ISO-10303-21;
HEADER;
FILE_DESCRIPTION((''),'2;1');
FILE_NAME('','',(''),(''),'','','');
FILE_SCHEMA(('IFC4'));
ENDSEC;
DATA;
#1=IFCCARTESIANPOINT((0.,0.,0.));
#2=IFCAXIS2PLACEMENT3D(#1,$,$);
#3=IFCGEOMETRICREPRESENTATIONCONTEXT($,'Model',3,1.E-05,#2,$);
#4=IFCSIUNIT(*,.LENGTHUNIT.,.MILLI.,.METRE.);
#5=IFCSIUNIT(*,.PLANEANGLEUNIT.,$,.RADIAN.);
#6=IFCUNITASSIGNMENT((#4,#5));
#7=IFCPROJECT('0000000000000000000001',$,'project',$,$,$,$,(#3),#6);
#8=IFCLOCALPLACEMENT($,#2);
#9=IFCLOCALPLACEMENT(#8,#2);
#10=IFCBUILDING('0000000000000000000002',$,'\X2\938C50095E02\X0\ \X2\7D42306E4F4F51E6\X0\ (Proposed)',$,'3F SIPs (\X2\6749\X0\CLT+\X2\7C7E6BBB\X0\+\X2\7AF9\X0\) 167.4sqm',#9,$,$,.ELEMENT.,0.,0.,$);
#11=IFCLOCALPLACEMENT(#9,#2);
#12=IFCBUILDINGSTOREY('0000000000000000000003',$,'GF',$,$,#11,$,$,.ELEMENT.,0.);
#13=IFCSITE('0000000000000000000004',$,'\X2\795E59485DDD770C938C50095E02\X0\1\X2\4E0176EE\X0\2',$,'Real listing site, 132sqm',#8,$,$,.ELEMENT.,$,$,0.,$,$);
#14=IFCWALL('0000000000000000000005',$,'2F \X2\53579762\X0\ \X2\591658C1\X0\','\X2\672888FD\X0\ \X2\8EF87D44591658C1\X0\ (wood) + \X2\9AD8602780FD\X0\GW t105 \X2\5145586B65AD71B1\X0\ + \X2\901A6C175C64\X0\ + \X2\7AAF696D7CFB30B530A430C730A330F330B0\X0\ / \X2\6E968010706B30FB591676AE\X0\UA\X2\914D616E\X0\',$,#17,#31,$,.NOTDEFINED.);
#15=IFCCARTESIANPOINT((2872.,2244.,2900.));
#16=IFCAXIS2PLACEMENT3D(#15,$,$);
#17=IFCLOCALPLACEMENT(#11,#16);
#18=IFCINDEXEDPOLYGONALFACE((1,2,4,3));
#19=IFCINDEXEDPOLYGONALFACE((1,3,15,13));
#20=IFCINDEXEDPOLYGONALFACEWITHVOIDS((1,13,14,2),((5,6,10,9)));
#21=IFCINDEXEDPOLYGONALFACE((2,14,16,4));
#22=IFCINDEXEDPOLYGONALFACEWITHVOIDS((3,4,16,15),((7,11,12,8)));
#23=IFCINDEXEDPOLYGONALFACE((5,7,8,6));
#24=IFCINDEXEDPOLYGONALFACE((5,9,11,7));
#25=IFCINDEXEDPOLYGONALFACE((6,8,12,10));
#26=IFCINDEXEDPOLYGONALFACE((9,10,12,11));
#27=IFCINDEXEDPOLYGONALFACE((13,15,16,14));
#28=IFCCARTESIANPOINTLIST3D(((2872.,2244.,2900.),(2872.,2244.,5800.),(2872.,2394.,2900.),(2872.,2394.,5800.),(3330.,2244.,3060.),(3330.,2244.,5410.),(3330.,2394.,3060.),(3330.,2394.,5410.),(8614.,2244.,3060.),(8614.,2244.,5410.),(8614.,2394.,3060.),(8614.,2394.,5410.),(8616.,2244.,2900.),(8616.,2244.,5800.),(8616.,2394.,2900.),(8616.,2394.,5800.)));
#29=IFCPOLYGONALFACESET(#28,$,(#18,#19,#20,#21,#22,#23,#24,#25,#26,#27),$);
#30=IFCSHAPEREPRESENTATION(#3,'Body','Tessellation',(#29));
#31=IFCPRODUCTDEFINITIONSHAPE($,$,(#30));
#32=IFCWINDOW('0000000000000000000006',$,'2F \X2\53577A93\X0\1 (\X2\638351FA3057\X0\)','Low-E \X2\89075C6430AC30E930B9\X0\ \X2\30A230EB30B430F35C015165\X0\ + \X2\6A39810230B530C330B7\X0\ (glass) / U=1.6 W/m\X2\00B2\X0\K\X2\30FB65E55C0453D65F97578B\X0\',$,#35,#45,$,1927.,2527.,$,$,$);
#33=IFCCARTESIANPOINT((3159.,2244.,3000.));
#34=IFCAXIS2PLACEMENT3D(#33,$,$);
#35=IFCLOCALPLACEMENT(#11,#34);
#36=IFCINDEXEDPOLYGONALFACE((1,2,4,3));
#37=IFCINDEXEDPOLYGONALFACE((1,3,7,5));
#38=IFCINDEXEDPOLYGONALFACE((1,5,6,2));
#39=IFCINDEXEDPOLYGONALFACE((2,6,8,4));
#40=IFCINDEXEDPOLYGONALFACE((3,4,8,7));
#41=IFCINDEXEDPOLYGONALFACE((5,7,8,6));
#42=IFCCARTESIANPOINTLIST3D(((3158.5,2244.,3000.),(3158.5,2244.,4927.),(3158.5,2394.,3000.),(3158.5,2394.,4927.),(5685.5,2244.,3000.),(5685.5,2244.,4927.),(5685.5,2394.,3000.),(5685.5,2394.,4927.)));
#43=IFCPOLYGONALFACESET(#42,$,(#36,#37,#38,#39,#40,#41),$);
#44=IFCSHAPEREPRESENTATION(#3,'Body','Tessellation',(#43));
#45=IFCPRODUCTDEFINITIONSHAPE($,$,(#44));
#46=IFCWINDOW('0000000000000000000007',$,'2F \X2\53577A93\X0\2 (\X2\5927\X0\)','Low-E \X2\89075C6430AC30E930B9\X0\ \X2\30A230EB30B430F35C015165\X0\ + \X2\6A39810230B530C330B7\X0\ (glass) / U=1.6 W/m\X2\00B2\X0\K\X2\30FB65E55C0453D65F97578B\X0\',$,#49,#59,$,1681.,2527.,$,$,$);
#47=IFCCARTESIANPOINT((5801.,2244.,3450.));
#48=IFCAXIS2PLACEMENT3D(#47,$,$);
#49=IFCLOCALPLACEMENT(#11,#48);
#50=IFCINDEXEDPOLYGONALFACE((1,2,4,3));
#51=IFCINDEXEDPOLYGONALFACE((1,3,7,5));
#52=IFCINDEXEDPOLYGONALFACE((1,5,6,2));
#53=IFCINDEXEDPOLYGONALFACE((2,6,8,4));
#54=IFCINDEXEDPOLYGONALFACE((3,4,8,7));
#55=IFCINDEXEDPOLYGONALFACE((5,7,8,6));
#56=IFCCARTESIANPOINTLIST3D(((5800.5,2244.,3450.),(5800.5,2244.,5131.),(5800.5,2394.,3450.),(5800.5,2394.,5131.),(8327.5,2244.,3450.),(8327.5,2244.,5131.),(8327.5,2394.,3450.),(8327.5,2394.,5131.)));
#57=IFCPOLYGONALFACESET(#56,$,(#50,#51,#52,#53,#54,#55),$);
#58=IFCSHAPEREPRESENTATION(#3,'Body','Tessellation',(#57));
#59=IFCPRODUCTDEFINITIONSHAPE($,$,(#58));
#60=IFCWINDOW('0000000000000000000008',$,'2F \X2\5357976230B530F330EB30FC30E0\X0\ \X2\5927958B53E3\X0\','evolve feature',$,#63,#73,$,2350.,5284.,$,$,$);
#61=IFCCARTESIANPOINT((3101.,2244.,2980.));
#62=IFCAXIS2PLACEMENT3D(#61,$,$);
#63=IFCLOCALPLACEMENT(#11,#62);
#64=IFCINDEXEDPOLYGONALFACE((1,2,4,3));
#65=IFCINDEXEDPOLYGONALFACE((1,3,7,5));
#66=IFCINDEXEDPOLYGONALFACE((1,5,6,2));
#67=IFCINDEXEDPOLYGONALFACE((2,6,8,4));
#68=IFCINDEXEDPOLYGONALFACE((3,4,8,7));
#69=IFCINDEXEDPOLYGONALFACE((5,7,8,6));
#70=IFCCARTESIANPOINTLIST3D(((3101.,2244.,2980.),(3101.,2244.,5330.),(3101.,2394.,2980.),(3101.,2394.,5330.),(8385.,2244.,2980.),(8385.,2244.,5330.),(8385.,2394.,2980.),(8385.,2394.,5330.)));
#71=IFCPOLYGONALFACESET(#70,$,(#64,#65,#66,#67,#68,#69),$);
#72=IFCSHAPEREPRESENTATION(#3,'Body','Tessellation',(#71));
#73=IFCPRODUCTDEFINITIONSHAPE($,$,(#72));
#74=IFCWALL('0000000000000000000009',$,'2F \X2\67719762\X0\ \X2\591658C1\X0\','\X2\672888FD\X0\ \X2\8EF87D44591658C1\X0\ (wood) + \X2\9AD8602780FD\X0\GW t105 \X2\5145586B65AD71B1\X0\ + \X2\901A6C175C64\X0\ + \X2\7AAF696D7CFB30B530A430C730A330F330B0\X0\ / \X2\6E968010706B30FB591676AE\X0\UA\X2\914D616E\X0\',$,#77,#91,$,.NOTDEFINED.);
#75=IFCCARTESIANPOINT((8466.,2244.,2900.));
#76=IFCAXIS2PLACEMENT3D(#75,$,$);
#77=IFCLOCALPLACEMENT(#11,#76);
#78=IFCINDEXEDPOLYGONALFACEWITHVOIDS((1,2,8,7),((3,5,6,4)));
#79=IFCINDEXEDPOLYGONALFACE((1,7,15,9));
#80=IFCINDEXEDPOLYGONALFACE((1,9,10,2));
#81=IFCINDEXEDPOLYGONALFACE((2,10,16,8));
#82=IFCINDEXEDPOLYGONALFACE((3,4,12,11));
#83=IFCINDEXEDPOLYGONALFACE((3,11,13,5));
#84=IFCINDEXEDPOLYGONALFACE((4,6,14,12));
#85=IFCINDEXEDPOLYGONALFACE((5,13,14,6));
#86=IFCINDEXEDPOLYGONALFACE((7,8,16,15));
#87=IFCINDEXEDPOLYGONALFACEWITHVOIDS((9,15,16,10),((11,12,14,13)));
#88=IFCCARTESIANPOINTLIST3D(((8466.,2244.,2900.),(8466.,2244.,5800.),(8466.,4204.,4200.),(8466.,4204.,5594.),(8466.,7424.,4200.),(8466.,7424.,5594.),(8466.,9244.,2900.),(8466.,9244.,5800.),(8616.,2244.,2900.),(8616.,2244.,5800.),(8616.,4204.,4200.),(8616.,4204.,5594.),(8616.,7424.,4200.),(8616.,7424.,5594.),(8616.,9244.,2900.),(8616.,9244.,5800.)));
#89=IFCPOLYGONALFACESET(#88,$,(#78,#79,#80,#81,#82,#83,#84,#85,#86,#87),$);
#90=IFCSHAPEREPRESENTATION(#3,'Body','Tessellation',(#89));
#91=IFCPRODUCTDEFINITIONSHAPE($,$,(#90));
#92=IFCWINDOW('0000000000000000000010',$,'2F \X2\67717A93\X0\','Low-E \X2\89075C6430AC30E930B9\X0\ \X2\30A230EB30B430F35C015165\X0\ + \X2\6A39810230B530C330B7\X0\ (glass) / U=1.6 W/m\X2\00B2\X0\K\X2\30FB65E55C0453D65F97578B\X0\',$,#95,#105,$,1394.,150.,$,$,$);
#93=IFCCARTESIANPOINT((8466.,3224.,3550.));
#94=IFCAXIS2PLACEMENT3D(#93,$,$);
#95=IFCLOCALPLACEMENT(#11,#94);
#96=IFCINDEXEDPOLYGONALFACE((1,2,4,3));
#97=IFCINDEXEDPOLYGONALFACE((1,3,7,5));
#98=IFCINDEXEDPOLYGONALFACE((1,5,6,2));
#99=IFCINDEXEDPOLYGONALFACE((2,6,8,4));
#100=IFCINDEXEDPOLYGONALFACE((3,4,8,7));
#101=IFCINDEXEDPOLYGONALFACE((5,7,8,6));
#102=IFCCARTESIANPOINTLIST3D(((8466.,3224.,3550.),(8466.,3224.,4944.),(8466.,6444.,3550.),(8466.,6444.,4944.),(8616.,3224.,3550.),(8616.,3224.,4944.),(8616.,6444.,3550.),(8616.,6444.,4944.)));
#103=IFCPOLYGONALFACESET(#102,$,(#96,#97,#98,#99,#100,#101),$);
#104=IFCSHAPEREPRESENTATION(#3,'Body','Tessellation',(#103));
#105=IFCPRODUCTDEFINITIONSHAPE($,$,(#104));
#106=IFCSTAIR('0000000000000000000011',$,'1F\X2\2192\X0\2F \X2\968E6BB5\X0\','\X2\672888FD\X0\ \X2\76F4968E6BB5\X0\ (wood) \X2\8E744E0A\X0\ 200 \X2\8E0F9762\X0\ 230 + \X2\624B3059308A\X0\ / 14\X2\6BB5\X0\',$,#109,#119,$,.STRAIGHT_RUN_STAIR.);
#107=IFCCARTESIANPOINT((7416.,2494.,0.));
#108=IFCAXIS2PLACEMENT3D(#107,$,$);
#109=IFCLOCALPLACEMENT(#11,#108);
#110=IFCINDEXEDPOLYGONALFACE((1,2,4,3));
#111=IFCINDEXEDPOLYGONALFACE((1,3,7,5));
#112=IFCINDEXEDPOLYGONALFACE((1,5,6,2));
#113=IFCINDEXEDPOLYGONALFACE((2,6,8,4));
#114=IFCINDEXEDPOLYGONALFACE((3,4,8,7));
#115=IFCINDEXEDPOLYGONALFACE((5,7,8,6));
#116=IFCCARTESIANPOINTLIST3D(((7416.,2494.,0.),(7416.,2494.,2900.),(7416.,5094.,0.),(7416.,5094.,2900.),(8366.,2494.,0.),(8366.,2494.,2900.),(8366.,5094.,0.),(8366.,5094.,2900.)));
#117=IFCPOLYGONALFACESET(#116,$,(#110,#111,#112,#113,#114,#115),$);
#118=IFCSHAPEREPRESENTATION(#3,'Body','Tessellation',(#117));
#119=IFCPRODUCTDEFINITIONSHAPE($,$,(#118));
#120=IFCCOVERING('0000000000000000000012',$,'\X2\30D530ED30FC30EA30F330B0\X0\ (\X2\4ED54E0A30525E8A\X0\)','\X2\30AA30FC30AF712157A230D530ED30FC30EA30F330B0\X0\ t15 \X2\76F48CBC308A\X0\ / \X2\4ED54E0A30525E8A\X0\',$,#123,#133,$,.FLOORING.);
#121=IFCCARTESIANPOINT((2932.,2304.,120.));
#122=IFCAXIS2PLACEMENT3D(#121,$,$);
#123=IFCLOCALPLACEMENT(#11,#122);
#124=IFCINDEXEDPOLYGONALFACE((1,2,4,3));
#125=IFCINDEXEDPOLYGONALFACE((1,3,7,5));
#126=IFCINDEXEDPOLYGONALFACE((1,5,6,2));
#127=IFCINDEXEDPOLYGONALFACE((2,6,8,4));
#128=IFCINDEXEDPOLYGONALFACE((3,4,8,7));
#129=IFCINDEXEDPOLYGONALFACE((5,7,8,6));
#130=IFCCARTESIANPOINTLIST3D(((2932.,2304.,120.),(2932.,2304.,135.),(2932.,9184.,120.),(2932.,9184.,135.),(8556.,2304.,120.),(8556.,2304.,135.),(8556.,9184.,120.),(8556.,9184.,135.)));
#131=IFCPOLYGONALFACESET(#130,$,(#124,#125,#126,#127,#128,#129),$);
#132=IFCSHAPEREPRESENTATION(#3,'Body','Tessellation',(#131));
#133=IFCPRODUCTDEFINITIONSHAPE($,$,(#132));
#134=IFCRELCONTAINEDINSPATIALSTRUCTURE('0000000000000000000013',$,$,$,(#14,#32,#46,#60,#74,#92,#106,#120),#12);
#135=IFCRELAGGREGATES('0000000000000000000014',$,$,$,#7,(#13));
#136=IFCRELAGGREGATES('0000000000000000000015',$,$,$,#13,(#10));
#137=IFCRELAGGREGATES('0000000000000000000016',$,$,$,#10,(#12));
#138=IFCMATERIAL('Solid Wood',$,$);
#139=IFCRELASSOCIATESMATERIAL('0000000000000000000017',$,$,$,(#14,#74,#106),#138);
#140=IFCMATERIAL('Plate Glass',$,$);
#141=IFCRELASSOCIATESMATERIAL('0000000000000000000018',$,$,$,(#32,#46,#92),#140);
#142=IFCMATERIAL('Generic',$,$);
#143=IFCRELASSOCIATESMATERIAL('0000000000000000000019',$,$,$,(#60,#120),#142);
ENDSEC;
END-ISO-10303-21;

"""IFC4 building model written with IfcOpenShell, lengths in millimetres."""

from ifc_helpers import new_model, si_unit, frame, frame_2d, origin, place, context, project, spatial, rectangle, extrude, material, element, fill, save


model = new_model("IFC4")

# Units and contexts
model_context = context("Model", 3, precision=1e-05, world=origin())
ifc_project = project(units=[si_unit("LENGTHUNIT", "METRE", prefix="MILLI"), si_unit("PLANEANGLEUNIT", "RADIAN")], contexts=[model_context])

# Site, building, storey
site_placement = place(None, origin())
site = spatial("IfcSite", under=ifc_project, at=site_placement, Name="神奈川県鎌倉市1丁目2", ObjectType="Real listing site, 132sqm", CompositionType="ELEMENT", RefElevation=0.0)
building_placement = place(site_placement, origin())
building = spatial("IfcBuilding", under=site, at=building_placement, Name="鎌倉市 終の住処 (Proposed)", ObjectType="3F SIPs (杉CLT+籾殻+竹) 167.4sqm", CompositionType="ELEMENT", ElevationOfRefHeight=0.0, ElevationOfTerrain=0.0)
storey_placement = place(building_placement, origin())
storey = spatial("IfcBuildingStorey", under=building, at=storey_placement, Name="GF", CompositionType="ELEMENT", Elevation=0.0)

# Shared definitions
ifc_material_1 = material(Name="Solid Wood")

# Shared definitions
ifc_material_2 = material(Name="Plate Glass")
ifc_material_3 = material(Name="Generic")

# Wall, openings, windows
wall_1_placement = place(storey_placement, frame((2872.0, 2244.0, 2900.0)))
wall_1 = element("IfcWall", 1, at=wall_1_placement, inside=storey, material=ifc_material_1, Name="2F 南面 外壁", Description="木製 軸組外壁 (wood) + 高性能GW t105 充填断熱 + 通気層 + 窯業系サイディング / 準耐火・外皮UA配慮", PredefinedType="NOTDEFINED", context=model_context, shape_type="SweptSolid", body=[
    extrude(rectangle(XDim=5744.0, YDim=150.0, at=frame_2d((2872.0, 75.0))), frame((2872.0, 2244.0, 2900.0)), (0.0, 0.0, 1.0), 2900.0),
])
opening_1_placement = place(storey_placement, frame((3159.0, 2244.0, 3000.0)))
opening_1 = element("IfcOpeningElement", 2, at=opening_1_placement, cuts=wall_1, PredefinedType="NOTDEFINED", context=model_context, shape_type="SweptSolid", body=[
    extrude(rectangle(XDim=2527.0, YDim=150.0, at=frame_2d((1263.0, 75.0))), frame((3159.0, 2244.0, 3000.0)), (0.0, 0.0, 1.0), 1927.0),
])
opening_2_placement = place(storey_placement, frame((5801.0, 2244.0, 3450.0)))
opening_2 = element("IfcOpeningElement", 3, at=opening_2_placement, cuts=wall_1, PredefinedType="NOTDEFINED", context=model_context, shape_type="SweptSolid", body=[
    extrude(rectangle(XDim=2527.0, YDim=150.0, at=frame_2d((1263.0, 75.0))), frame((5801.0, 2244.0, 3450.0)), (0.0, 0.0, 1.0), 1681.0),
])
opening_3_placement = place(storey_placement, frame((3101.0, 2244.0, 2980.0)))
opening_3 = element("IfcOpeningElement", 4, at=opening_3_placement, cuts=wall_1, PredefinedType="NOTDEFINED", context=model_context, shape_type="SweptSolid", body=[
    extrude(rectangle(XDim=5284.0, YDim=150.0, at=frame_2d((2642.0, 75.0))), frame((3101.0, 2244.0, 2980.0)), (0.0, 0.0, 1.0), 2350.0),
])
window_1_placement = place(storey_placement, frame((3159.0, 2244.0, 3000.0)))
window_1 = element("IfcWindow", 5, at=window_1_placement, inside=storey, material=ifc_material_2, Name="2F 南窓1 (掃出し)", Description="Low-E 複層ガラス アルゴン封入 + 樹脂サッシ (glass) / U=1.6 W/m²K・日射取得型", OverallHeight=1927.0, OverallWidth=2527.0, context=model_context, shape_type="SweptSolid", body=[
    extrude(rectangle(XDim=2527.0, YDim=150.0, at=frame_2d((1263.0, 75.0))), frame((3159.0, 2244.0, 3000.0)), (0.0, 0.0, 1.0), 1927.0),
])
fill(opening_1, window_1)
window_2_placement = place(storey_placement, frame((5801.0, 2244.0, 3450.0)))
window_2 = element("IfcWindow", 6, at=window_2_placement, inside=storey, material=ifc_material_2, Name="2F 南窓2 (大)", Description="Low-E 複層ガラス アルゴン封入 + 樹脂サッシ (glass) / U=1.6 W/m²K・日射取得型", OverallHeight=1681.0, OverallWidth=2527.0, context=model_context, shape_type="SweptSolid", body=[
    extrude(rectangle(XDim=2527.0, YDim=150.0, at=frame_2d((1263.0, 75.0))), frame((5801.0, 2244.0, 3450.0)), (0.0, 0.0, 1.0), 1681.0),
])
fill(opening_2, window_2)
window_3_placement = place(storey_placement, frame((3101.0, 2244.0, 2980.0)))
window_3 = element("IfcWindow", 7, at=window_3_placement, inside=storey, material=ifc_material_3, Name="2F 南面サンルーム 大開口", Description="evolve feature", OverallHeight=2350.0, OverallWidth=5284.0, context=model_context, shape_type="SweptSolid", body=[
    extrude(rectangle(XDim=5284.0, YDim=150.0, at=frame_2d((2642.0, 75.0))), frame((3101.0, 2244.0, 2980.0)), (0.0, 0.0, 1.0), 2350.0),
])
fill(opening_3, window_3)

# Wall, opening, window
wall_2_placement = place(storey_placement, frame((8466.0, 2244.0, 2900.0)))
wall_2 = element("IfcWall", 8, at=wall_2_placement, inside=storey, material=ifc_material_1, Name="2F 東面 外壁", Description="木製 軸組外壁 (wood) + 高性能GW t105 充填断熱 + 通気層 + 窯業系サイディング / 準耐火・外皮UA配慮", PredefinedType="NOTDEFINED", context=model_context, shape_type="SweptSolid", body=[
    extrude(rectangle(XDim=150.0, YDim=7000.0, at=frame_2d((75.0, 3500.0))), frame((8466.0, 2244.0, 2900.0)), (0.0, 0.0, 1.0), 2900.0),
])
opening_4_placement = place(storey_placement, frame((8466.0, 3224.0, 3550.0)))
opening_4 = element("IfcOpeningElement", 9, at=opening_4_placement, cuts=wall_2, PredefinedType="NOTDEFINED", context=model_context, shape_type="SweptSolid", body=[
    extrude(rectangle(XDim=150.0, YDim=3220.0, at=frame_2d((75.0, 1610.0))), frame((8466.0, 3224.0, 3550.0)), (0.0, 0.0, 1.0), 1394.0),
])
window_4_placement = place(storey_placement, frame((8466.0, 3224.0, 3550.0)))
window_4 = element("IfcWindow", 10, at=window_4_placement, inside=storey, material=ifc_material_2, Name="2F 東窓", Description="Low-E 複層ガラス アルゴン封入 + 樹脂サッシ (glass) / U=1.6 W/m²K・日射取得型", OverallHeight=1394.0, OverallWidth=150.0, context=model_context, shape_type="SweptSolid", body=[
    extrude(rectangle(XDim=150.0, YDim=3220.0, at=frame_2d((75.0, 1610.0))), frame((8466.0, 3224.0, 3550.0)), (0.0, 0.0, 1.0), 1394.0),
])
fill(opening_4, window_4)

# Stair
stair_placement = place(storey_placement, frame((7416.0, 2494.0, 0.0)))
element("IfcStair", 11, at=stair_placement, inside=storey, material=ifc_material_1, Name="1F→2F 階段", Description="木製 直階段 (wood) 蹴上 200 踏面 230 + 手すり / 14段", PredefinedType="STRAIGHT_RUN_STAIR", context=model_context, shape_type="SweptSolid", body=[
    extrude(rectangle(XDim=950.0, YDim=2600.0, at=frame_2d((475.0, 1300.0))), frame((7416.0, 2494.0, 0.0)), (0.0, 0.0, 1.0), 2900.0),
])

# Covering
covering_placement = place(storey_placement, frame((2932.0, 2304.0, 120.0)))
element("IfcCovering", 12, at=covering_placement, inside=storey, material=ifc_material_3, Name="フローリング (仕上げ床)", Description="オーク無垢フローリング t15 直貼り / 仕上げ床", PredefinedType="FLOORING", context=model_context, shape_type="SweptSolid", body=[
    extrude(rectangle(XDim=5624.0, YDim=6880.0, at=frame_2d((2812.0, 3440.0))), frame((2932.0, 2304.0, 120.0)), (0.0, 0.0, 1.0), 15.0),
])

save(model, "model.ifc")
